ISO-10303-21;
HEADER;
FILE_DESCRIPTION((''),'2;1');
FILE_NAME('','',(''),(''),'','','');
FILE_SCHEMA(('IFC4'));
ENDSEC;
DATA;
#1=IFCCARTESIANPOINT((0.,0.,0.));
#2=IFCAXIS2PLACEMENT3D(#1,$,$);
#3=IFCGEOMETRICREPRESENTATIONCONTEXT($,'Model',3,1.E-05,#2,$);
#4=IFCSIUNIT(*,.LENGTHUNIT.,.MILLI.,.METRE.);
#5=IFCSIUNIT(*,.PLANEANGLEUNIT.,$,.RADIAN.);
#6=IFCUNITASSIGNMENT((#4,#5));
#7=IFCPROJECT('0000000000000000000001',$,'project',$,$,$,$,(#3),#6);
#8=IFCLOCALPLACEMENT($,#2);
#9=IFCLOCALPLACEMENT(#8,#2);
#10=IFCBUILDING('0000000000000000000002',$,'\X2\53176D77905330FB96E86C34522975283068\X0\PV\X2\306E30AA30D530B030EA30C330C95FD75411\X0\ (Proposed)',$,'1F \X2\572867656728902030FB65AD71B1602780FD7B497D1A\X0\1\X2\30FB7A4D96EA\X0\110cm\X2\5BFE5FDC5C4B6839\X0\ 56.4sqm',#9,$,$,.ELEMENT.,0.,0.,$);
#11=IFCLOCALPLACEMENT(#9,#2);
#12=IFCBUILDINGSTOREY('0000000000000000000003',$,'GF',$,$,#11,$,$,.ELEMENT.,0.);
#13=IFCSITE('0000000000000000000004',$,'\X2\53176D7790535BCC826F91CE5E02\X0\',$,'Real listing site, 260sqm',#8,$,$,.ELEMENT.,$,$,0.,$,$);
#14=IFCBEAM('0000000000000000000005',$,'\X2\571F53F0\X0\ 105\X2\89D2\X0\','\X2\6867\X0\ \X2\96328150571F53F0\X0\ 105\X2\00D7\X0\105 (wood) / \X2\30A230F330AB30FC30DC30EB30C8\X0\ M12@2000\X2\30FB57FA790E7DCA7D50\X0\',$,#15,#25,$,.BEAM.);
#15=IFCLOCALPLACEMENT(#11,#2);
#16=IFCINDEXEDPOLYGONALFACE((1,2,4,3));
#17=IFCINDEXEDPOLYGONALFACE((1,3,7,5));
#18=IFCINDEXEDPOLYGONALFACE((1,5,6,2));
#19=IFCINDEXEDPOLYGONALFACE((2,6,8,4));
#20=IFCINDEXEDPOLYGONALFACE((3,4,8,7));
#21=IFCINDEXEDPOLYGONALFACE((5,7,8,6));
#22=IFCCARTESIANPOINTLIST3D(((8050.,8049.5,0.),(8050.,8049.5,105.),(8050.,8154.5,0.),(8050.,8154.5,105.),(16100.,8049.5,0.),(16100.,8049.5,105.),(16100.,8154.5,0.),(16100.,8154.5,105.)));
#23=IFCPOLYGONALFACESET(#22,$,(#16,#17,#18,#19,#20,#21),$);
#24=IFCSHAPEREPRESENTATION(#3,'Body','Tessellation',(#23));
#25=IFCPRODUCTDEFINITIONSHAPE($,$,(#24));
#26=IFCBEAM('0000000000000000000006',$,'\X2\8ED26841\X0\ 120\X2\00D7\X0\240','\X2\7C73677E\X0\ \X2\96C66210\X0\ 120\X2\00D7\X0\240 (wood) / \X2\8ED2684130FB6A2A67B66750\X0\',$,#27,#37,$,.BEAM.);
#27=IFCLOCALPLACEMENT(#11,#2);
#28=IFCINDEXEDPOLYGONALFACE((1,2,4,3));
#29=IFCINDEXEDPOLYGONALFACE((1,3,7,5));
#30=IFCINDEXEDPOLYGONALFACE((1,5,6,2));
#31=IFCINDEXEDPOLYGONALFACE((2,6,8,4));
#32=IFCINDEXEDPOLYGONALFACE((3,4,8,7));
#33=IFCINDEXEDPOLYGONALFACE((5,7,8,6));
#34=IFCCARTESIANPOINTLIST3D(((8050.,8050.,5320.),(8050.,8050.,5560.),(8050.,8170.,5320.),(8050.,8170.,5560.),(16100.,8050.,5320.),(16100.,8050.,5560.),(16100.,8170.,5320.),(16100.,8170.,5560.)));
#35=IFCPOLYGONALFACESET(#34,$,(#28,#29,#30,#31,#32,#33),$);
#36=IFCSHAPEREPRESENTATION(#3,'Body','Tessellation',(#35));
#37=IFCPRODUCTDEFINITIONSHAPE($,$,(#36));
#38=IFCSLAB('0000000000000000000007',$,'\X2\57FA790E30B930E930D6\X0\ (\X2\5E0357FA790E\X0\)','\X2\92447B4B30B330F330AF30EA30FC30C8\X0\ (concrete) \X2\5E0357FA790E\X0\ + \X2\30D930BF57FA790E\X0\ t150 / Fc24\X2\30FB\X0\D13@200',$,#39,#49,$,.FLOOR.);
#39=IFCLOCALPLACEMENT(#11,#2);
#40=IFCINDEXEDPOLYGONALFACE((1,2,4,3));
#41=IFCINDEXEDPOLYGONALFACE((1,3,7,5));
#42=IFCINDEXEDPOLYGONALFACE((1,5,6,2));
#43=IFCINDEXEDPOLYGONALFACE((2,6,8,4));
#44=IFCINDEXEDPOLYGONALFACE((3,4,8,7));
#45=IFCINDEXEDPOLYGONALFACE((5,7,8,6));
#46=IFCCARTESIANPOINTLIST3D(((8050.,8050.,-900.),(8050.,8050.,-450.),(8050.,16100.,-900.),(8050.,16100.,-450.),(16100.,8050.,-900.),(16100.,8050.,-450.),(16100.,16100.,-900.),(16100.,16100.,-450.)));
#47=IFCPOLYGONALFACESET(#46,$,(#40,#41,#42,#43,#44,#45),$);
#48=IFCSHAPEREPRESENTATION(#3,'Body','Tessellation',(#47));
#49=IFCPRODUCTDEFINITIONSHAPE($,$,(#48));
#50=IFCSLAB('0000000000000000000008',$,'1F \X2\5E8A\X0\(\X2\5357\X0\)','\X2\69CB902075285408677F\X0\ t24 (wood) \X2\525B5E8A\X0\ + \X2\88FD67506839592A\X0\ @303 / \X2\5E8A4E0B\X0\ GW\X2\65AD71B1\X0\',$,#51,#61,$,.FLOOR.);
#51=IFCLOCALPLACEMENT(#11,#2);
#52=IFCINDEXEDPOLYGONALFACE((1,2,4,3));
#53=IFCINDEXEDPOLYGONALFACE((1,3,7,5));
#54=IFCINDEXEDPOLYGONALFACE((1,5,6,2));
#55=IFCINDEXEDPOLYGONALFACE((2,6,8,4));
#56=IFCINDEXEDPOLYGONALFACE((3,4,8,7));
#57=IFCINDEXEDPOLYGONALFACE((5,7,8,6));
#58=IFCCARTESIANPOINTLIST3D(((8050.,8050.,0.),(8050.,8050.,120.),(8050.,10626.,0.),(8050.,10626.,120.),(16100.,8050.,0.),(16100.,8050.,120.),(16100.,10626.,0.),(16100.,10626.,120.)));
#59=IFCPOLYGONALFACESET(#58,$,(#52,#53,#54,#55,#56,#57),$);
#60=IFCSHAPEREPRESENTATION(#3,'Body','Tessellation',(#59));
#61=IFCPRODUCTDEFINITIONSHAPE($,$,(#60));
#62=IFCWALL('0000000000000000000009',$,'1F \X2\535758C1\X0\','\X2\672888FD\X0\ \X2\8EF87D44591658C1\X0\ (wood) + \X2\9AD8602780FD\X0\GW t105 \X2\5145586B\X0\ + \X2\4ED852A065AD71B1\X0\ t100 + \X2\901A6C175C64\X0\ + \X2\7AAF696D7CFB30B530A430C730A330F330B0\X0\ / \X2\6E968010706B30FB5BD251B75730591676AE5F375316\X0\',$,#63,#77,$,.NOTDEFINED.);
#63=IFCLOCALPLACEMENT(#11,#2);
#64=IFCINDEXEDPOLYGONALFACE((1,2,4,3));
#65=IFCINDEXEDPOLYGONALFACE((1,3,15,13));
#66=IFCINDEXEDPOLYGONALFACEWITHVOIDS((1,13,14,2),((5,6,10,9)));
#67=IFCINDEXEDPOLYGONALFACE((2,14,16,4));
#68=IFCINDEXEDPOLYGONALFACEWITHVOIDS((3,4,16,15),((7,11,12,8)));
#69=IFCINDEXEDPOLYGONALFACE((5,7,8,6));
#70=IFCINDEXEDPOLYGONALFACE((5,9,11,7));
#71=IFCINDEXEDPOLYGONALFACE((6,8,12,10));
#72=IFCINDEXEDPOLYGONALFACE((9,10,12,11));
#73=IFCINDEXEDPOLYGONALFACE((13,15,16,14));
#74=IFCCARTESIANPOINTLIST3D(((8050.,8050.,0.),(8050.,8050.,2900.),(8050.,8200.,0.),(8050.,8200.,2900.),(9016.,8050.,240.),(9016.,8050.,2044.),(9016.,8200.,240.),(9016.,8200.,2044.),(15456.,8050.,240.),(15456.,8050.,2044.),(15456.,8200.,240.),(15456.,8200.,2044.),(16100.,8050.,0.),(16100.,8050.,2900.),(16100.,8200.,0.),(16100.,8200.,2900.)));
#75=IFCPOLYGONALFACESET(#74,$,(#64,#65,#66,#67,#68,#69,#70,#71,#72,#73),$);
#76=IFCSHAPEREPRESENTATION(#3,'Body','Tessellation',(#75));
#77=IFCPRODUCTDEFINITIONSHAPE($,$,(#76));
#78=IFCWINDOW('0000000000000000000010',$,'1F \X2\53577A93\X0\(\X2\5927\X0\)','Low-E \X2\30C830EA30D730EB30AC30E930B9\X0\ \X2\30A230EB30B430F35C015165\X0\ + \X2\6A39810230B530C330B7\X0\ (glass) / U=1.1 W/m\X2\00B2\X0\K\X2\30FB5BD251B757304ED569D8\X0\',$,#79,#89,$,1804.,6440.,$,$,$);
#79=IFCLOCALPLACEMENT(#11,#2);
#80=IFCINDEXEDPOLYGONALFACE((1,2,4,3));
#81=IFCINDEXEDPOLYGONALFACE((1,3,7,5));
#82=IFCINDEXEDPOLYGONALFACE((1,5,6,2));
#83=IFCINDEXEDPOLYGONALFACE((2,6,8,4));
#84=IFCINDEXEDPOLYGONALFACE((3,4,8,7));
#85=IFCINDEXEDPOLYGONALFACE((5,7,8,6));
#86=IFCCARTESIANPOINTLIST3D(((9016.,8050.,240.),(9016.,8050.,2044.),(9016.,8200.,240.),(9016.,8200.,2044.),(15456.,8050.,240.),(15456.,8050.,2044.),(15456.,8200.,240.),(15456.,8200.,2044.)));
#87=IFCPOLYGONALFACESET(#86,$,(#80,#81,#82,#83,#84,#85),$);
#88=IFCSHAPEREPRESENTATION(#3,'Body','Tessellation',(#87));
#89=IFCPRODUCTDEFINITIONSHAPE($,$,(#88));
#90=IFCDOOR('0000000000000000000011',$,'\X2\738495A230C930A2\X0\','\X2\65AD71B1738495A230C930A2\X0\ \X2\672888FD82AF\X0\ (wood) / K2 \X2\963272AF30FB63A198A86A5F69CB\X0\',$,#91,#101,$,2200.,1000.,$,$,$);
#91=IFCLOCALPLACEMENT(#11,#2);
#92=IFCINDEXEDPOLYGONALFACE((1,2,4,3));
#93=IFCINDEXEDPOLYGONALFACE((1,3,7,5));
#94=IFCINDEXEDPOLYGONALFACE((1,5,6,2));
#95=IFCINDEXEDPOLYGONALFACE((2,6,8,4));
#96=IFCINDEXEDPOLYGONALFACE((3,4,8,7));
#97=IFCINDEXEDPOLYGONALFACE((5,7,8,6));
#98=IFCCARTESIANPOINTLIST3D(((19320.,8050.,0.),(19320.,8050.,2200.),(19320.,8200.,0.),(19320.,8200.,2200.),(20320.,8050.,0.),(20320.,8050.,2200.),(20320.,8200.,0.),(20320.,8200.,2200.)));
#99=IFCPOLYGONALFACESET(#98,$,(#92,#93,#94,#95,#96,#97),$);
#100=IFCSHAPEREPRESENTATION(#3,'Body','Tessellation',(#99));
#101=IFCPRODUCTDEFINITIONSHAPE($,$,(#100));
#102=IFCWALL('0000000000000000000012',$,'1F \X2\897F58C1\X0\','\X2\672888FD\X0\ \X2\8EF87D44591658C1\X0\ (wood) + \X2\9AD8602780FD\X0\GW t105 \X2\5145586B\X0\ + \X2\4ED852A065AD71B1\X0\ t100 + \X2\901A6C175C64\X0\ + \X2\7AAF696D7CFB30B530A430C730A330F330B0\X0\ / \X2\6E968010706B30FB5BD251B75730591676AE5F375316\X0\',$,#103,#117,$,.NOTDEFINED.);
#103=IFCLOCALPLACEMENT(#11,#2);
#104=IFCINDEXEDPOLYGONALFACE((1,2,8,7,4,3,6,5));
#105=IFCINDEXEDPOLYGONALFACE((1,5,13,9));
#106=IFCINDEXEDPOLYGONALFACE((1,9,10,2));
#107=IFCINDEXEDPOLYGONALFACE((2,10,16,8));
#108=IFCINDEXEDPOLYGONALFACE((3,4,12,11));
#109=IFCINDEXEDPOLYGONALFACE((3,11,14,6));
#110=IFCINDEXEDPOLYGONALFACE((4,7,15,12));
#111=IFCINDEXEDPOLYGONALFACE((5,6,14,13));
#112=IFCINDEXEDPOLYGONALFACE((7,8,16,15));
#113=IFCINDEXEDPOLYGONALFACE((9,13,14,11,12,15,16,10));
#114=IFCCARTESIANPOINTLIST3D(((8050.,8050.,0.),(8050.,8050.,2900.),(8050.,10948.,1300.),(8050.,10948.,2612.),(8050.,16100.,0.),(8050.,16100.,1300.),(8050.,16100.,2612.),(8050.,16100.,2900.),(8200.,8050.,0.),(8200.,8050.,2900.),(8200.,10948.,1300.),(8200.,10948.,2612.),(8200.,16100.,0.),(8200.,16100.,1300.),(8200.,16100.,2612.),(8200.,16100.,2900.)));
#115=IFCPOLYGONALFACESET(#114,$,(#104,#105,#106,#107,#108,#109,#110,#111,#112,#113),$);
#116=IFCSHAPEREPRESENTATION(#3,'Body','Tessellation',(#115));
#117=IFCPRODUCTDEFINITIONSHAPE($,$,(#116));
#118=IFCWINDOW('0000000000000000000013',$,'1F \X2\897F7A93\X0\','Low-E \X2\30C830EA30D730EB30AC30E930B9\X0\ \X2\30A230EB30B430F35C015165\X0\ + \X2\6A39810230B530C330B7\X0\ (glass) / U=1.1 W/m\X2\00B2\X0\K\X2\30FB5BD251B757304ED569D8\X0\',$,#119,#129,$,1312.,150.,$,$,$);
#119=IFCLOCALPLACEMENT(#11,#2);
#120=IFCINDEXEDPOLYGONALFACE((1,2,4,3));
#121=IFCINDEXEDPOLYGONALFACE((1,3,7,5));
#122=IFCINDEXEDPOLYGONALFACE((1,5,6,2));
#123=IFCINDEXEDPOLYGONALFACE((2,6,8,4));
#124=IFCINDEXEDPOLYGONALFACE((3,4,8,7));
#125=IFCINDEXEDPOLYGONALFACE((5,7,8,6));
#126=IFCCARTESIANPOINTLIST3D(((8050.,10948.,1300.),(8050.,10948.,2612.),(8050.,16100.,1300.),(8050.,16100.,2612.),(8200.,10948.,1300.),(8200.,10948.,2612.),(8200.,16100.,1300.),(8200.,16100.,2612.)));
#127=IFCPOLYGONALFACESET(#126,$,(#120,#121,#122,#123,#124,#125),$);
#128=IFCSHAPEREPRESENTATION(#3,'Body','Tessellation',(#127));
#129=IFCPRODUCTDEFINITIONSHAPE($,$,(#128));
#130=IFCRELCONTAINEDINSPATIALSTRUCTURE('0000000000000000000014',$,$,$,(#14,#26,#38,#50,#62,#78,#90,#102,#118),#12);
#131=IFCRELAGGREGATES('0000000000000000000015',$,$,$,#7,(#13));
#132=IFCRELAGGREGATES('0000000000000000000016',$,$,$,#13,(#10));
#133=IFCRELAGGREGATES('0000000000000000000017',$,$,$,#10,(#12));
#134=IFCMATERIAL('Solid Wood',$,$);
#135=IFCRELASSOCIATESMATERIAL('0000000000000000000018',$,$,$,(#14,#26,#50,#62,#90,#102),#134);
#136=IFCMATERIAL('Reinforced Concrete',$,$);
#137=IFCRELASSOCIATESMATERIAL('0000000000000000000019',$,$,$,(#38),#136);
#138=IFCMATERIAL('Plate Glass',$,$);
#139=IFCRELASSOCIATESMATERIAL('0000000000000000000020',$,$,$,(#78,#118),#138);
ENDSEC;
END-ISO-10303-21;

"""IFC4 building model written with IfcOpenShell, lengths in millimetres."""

from ifc_helpers import new_model, si_unit, frame, frame_2d, origin, place, context, project, spatial, rectangle, extrude, material, element, fill, save


model = new_model("IFC4")

# Units and contexts
model_context = context("Model", 3, precision=1e-05, world=origin())
ifc_project = project(units=[si_unit("LENGTHUNIT", "METRE", prefix="MILLI"), si_unit("PLANEANGLEUNIT", "RADIAN")], contexts=[model_context])

# Site, building, storey
site_placement = place(None, origin())
site = spatial("IfcSite", under=ifc_project, at=site_placement, Name="北海道富良野市", ObjectType="Real listing site, 260sqm", CompositionType="ELEMENT", RefElevation=0.0)
building_placement = place(site_placement, origin())
building = spatial("IfcBuilding", under=site, at=building_placement, Name="北海道・雨水利用とPVのオフグリッド志向 (Proposed)", ObjectType="1F 在来木造・断熱性能等級1・積雪110cm対応屋根 56.4sqm", CompositionType="ELEMENT", ElevationOfRefHeight=0.0, ElevationOfTerrain=0.0)
storey_placement = place(building_placement, origin())
storey = spatial("IfcBuildingStorey", under=building, at=storey_placement, Name="GF", CompositionType="ELEMENT", Elevation=0.0)

# Shared definitions
ifc_material_1 = material(Name="Solid Wood")

# Beams
beam_1_placement = place(storey_placement, frame((4025.0, 4025.0, 0.0)))
element("IfcBeam", 1, at=beam_1_placement, inside=storey, material=ifc_material_1, Name="土台 105角", Description="桧 防腐土台 105×105 (wood) / アンカーボルト M12@2000・基礎緊結", PredefinedType="BEAM", context=model_context, shape_type="SweptSolid", body=[
    extrude(rectangle(XDim=8050.0, YDim=105.0, at=frame_2d((4025.0, 52.0))), frame((4025.0, 4025.0, 0.0)), (0.0, 0.0, 1.0), 105.0),
])
beam_2_placement = place(storey_placement, frame((4025.0, 4025.0, 2660.0)))
element("IfcBeam", 2, at=beam_2_placement, inside=storey, material=ifc_material_1, Name="軒桁 120×240", Description="米松 集成 120×240 (wood) / 軒桁・横架材", PredefinedType="BEAM", context=model_context, shape_type="SweptSolid", body=[
    extrude(rectangle(XDim=8050.0, YDim=120.0, at=frame_2d((4025.0, 60.0))), frame((4025.0, 4025.0, 2660.0)), (0.0, 0.0, 1.0), 240.0),
])

# Slabs
ifc_material_2 = material(Name="Reinforced Concrete")
slab_1_placement = place(storey_placement, frame((4025.0, 4025.0, -450.0)))
element("IfcSlab", 3, at=slab_1_placement, inside=storey, material=ifc_material_2, Name="基礎スラブ (布基礎)", Description="鉄筋コンクリート (concrete) 布基礎 + ベタ基礎 t150 / Fc24・D13@200", PredefinedType="FLOOR", context=model_context, shape_type="SweptSolid", body=[
    extrude(rectangle(XDim=8050.0, YDim=8050.0, at=frame_2d((4025.0, 4025.0))), frame((4025.0, 4025.0, -450.0)), (0.0, 0.0, 1.0), 450.0),
])
slab_2_placement = place(storey_placement, frame((4025.0, 4025.0, 0.0)))
element("IfcSlab", 4, at=slab_2_placement, inside=storey, material=ifc_material_1, Name="1F 床(南)", Description="構造用合板 t24 (wood) 剛床 + 製材根太 @303 / 床下 GW断熱", PredefinedType="FLOOR", context=model_context, shape_type="SweptSolid", body=[
    extrude(rectangle(XDim=8050.0, YDim=2576.0, at=frame_2d((4025.0, 1288.0))), frame((4025.0, 4025.0, 0.0)), (0.0, 0.0, 1.0), 120.0),
])

# Wall, openings, window, door
wall_1_placement = place(storey_placement, frame((4025.0, 4025.0, 0.0)))
wall_1 = element("IfcWall", 5, at=wall_1_placement, inside=storey, material=ifc_material_1, Name="1F 南壁", Description="木製 軸組外壁 (wood) + 高性能GW t105 充填 + 付加断熱 t100 + 通気層 + 窯業系サイディング / 準耐火・寒冷地外皮強化", PredefinedType="NOTDEFINED", context=model_context, shape_type="SweptSolid", body=[
    extrude(rectangle(XDim=8050.0, YDim=150.0, at=frame_2d((4025.0, 75.0))), frame((4025.0, 4025.0, 0.0)), (0.0, 0.0, 1.0), 2900.0),
])
opening_1_placement = place(storey_placement, frame((4508.0, 4025.0, 120.0)))
opening_1 = element("IfcOpeningElement", 6, at=opening_1_placement, cuts=wall_1, PredefinedType="NOTDEFINED", context=model_context, shape_type="SweptSolid", body=[
    extrude(rectangle(XDim=6440.0, YDim=150.0, at=frame_2d((3220.0, 75.0))), frame((4508.0, 4025.0, 120.0)), (0.0, 0.0, 1.0), 1804.0),
])
opening_2_placement = place(storey_placement, frame((9660.0, 4025.0, 0.0)))
opening_2 = element("IfcOpeningElement", 7, at=opening_2_placement, cuts=wall_1, PredefinedType="NOTDEFINED", context=model_context, shape_type="SweptSolid", body=[
    extrude(rectangle(XDim=1000.0, YDim=150.0, at=frame_2d((500.0, 75.0))), frame((9660.0, 4025.0, 0.0)), (0.0, 0.0, 1.0), 2200.0),
])
ifc_material_3 = material(Name="Plate Glass")
window_1_placement = place(storey_placement, frame((4508.0, 4025.0, 120.0)))
window_1 = element("IfcWindow", 8, at=window_1_placement, inside=storey, material=ifc_material_3, Name="1F 南窓(大)", Description="Low-E トリプルガラス アルゴン封入 + 樹脂サッシ (glass) / U=1.1 W/m²K・寒冷地仕様", OverallHeight=1804.0, OverallWidth=6440.0, context=model_context, shape_type="SweptSolid", body=[
    extrude(rectangle(XDim=6440.0, YDim=150.0, at=frame_2d((3220.0, 75.0))), frame((4508.0, 4025.0, 120.0)), (0.0, 0.0, 1.0), 1804.0),
])
fill(opening_1, window_1)
door_placement = place(storey_placement, frame((9660.0, 4025.0, 0.0)))
door = element("IfcDoor", 9, at=door_placement, inside=storey, material=ifc_material_1, Name="玄関ドア", Description="断熱玄関ドア 木製芯 (wood) / K2 防犯・採風機構", OverallHeight=2200.0, OverallWidth=1000.0, context=model_context, shape_type="SweptSolid", body=[
    extrude(rectangle(XDim=1000.0, YDim=150.0, at=frame_2d((500.0, 75.0))), frame((9660.0, 4025.0, 0.0)), (0.0, 0.0, 1.0), 2200.0),
])
fill(opening_2, door)

# Wall, opening, window
wall_2_placement = place(storey_placement, frame((4025.0, 4025.0, 0.0)))
wall_2 = element("IfcWall", 10, at=wall_2_placement, inside=storey, material=ifc_material_1, Name="1F 西壁", Description="木製 軸組外壁 (wood) + 高性能GW t105 充填 + 付加断熱 t100 + 通気層 + 窯業系サイディング / 準耐火・寒冷地外皮強化", PredefinedType="NOTDEFINED", context=model_context, shape_type="SweptSolid", body=[
    extrude(rectangle(XDim=150.0, YDim=8050.0, at=frame_2d((75.0, 4025.0))), frame((4025.0, 4025.0, 0.0)), (0.0, 0.0, 1.0), 2900.0),
])
opening_3_placement = place(storey_placement, frame((4025.0, 5474.0, 650.0)))
opening_3 = element("IfcOpeningElement", 11, at=opening_3_placement, cuts=wall_2, PredefinedType="NOTDEFINED", context=model_context, shape_type="SweptSolid", body=[
    extrude(rectangle(XDim=150.0, YDim=5152.0, at=frame_2d((75.0, 2576.0))), frame((4025.0, 5474.0, 650.0)), (0.0, 0.0, 1.0), 1312.0),
])
window_2_placement = place(storey_placement, frame((4025.0, 5474.0, 650.0)))
window_2 = element("IfcWindow", 12, at=window_2_placement, inside=storey, material=ifc_material_3, Name="1F 西窓", Description="Low-E トリプルガラス アルゴン封入 + 樹脂サッシ (glass) / U=1.1 W/m²K・寒冷地仕様", OverallHeight=1312.0, OverallWidth=150.0, context=model_context, shape_type="SweptSolid", body=[
    extrude(rectangle(XDim=150.0, YDim=5152.0, at=frame_2d((75.0, 2576.0))), frame((4025.0, 5474.0, 650.0)), (0.0, 0.0, 1.0), 1312.0),
])
fill(opening_3, window_2)

save(model, "model.ifc")
